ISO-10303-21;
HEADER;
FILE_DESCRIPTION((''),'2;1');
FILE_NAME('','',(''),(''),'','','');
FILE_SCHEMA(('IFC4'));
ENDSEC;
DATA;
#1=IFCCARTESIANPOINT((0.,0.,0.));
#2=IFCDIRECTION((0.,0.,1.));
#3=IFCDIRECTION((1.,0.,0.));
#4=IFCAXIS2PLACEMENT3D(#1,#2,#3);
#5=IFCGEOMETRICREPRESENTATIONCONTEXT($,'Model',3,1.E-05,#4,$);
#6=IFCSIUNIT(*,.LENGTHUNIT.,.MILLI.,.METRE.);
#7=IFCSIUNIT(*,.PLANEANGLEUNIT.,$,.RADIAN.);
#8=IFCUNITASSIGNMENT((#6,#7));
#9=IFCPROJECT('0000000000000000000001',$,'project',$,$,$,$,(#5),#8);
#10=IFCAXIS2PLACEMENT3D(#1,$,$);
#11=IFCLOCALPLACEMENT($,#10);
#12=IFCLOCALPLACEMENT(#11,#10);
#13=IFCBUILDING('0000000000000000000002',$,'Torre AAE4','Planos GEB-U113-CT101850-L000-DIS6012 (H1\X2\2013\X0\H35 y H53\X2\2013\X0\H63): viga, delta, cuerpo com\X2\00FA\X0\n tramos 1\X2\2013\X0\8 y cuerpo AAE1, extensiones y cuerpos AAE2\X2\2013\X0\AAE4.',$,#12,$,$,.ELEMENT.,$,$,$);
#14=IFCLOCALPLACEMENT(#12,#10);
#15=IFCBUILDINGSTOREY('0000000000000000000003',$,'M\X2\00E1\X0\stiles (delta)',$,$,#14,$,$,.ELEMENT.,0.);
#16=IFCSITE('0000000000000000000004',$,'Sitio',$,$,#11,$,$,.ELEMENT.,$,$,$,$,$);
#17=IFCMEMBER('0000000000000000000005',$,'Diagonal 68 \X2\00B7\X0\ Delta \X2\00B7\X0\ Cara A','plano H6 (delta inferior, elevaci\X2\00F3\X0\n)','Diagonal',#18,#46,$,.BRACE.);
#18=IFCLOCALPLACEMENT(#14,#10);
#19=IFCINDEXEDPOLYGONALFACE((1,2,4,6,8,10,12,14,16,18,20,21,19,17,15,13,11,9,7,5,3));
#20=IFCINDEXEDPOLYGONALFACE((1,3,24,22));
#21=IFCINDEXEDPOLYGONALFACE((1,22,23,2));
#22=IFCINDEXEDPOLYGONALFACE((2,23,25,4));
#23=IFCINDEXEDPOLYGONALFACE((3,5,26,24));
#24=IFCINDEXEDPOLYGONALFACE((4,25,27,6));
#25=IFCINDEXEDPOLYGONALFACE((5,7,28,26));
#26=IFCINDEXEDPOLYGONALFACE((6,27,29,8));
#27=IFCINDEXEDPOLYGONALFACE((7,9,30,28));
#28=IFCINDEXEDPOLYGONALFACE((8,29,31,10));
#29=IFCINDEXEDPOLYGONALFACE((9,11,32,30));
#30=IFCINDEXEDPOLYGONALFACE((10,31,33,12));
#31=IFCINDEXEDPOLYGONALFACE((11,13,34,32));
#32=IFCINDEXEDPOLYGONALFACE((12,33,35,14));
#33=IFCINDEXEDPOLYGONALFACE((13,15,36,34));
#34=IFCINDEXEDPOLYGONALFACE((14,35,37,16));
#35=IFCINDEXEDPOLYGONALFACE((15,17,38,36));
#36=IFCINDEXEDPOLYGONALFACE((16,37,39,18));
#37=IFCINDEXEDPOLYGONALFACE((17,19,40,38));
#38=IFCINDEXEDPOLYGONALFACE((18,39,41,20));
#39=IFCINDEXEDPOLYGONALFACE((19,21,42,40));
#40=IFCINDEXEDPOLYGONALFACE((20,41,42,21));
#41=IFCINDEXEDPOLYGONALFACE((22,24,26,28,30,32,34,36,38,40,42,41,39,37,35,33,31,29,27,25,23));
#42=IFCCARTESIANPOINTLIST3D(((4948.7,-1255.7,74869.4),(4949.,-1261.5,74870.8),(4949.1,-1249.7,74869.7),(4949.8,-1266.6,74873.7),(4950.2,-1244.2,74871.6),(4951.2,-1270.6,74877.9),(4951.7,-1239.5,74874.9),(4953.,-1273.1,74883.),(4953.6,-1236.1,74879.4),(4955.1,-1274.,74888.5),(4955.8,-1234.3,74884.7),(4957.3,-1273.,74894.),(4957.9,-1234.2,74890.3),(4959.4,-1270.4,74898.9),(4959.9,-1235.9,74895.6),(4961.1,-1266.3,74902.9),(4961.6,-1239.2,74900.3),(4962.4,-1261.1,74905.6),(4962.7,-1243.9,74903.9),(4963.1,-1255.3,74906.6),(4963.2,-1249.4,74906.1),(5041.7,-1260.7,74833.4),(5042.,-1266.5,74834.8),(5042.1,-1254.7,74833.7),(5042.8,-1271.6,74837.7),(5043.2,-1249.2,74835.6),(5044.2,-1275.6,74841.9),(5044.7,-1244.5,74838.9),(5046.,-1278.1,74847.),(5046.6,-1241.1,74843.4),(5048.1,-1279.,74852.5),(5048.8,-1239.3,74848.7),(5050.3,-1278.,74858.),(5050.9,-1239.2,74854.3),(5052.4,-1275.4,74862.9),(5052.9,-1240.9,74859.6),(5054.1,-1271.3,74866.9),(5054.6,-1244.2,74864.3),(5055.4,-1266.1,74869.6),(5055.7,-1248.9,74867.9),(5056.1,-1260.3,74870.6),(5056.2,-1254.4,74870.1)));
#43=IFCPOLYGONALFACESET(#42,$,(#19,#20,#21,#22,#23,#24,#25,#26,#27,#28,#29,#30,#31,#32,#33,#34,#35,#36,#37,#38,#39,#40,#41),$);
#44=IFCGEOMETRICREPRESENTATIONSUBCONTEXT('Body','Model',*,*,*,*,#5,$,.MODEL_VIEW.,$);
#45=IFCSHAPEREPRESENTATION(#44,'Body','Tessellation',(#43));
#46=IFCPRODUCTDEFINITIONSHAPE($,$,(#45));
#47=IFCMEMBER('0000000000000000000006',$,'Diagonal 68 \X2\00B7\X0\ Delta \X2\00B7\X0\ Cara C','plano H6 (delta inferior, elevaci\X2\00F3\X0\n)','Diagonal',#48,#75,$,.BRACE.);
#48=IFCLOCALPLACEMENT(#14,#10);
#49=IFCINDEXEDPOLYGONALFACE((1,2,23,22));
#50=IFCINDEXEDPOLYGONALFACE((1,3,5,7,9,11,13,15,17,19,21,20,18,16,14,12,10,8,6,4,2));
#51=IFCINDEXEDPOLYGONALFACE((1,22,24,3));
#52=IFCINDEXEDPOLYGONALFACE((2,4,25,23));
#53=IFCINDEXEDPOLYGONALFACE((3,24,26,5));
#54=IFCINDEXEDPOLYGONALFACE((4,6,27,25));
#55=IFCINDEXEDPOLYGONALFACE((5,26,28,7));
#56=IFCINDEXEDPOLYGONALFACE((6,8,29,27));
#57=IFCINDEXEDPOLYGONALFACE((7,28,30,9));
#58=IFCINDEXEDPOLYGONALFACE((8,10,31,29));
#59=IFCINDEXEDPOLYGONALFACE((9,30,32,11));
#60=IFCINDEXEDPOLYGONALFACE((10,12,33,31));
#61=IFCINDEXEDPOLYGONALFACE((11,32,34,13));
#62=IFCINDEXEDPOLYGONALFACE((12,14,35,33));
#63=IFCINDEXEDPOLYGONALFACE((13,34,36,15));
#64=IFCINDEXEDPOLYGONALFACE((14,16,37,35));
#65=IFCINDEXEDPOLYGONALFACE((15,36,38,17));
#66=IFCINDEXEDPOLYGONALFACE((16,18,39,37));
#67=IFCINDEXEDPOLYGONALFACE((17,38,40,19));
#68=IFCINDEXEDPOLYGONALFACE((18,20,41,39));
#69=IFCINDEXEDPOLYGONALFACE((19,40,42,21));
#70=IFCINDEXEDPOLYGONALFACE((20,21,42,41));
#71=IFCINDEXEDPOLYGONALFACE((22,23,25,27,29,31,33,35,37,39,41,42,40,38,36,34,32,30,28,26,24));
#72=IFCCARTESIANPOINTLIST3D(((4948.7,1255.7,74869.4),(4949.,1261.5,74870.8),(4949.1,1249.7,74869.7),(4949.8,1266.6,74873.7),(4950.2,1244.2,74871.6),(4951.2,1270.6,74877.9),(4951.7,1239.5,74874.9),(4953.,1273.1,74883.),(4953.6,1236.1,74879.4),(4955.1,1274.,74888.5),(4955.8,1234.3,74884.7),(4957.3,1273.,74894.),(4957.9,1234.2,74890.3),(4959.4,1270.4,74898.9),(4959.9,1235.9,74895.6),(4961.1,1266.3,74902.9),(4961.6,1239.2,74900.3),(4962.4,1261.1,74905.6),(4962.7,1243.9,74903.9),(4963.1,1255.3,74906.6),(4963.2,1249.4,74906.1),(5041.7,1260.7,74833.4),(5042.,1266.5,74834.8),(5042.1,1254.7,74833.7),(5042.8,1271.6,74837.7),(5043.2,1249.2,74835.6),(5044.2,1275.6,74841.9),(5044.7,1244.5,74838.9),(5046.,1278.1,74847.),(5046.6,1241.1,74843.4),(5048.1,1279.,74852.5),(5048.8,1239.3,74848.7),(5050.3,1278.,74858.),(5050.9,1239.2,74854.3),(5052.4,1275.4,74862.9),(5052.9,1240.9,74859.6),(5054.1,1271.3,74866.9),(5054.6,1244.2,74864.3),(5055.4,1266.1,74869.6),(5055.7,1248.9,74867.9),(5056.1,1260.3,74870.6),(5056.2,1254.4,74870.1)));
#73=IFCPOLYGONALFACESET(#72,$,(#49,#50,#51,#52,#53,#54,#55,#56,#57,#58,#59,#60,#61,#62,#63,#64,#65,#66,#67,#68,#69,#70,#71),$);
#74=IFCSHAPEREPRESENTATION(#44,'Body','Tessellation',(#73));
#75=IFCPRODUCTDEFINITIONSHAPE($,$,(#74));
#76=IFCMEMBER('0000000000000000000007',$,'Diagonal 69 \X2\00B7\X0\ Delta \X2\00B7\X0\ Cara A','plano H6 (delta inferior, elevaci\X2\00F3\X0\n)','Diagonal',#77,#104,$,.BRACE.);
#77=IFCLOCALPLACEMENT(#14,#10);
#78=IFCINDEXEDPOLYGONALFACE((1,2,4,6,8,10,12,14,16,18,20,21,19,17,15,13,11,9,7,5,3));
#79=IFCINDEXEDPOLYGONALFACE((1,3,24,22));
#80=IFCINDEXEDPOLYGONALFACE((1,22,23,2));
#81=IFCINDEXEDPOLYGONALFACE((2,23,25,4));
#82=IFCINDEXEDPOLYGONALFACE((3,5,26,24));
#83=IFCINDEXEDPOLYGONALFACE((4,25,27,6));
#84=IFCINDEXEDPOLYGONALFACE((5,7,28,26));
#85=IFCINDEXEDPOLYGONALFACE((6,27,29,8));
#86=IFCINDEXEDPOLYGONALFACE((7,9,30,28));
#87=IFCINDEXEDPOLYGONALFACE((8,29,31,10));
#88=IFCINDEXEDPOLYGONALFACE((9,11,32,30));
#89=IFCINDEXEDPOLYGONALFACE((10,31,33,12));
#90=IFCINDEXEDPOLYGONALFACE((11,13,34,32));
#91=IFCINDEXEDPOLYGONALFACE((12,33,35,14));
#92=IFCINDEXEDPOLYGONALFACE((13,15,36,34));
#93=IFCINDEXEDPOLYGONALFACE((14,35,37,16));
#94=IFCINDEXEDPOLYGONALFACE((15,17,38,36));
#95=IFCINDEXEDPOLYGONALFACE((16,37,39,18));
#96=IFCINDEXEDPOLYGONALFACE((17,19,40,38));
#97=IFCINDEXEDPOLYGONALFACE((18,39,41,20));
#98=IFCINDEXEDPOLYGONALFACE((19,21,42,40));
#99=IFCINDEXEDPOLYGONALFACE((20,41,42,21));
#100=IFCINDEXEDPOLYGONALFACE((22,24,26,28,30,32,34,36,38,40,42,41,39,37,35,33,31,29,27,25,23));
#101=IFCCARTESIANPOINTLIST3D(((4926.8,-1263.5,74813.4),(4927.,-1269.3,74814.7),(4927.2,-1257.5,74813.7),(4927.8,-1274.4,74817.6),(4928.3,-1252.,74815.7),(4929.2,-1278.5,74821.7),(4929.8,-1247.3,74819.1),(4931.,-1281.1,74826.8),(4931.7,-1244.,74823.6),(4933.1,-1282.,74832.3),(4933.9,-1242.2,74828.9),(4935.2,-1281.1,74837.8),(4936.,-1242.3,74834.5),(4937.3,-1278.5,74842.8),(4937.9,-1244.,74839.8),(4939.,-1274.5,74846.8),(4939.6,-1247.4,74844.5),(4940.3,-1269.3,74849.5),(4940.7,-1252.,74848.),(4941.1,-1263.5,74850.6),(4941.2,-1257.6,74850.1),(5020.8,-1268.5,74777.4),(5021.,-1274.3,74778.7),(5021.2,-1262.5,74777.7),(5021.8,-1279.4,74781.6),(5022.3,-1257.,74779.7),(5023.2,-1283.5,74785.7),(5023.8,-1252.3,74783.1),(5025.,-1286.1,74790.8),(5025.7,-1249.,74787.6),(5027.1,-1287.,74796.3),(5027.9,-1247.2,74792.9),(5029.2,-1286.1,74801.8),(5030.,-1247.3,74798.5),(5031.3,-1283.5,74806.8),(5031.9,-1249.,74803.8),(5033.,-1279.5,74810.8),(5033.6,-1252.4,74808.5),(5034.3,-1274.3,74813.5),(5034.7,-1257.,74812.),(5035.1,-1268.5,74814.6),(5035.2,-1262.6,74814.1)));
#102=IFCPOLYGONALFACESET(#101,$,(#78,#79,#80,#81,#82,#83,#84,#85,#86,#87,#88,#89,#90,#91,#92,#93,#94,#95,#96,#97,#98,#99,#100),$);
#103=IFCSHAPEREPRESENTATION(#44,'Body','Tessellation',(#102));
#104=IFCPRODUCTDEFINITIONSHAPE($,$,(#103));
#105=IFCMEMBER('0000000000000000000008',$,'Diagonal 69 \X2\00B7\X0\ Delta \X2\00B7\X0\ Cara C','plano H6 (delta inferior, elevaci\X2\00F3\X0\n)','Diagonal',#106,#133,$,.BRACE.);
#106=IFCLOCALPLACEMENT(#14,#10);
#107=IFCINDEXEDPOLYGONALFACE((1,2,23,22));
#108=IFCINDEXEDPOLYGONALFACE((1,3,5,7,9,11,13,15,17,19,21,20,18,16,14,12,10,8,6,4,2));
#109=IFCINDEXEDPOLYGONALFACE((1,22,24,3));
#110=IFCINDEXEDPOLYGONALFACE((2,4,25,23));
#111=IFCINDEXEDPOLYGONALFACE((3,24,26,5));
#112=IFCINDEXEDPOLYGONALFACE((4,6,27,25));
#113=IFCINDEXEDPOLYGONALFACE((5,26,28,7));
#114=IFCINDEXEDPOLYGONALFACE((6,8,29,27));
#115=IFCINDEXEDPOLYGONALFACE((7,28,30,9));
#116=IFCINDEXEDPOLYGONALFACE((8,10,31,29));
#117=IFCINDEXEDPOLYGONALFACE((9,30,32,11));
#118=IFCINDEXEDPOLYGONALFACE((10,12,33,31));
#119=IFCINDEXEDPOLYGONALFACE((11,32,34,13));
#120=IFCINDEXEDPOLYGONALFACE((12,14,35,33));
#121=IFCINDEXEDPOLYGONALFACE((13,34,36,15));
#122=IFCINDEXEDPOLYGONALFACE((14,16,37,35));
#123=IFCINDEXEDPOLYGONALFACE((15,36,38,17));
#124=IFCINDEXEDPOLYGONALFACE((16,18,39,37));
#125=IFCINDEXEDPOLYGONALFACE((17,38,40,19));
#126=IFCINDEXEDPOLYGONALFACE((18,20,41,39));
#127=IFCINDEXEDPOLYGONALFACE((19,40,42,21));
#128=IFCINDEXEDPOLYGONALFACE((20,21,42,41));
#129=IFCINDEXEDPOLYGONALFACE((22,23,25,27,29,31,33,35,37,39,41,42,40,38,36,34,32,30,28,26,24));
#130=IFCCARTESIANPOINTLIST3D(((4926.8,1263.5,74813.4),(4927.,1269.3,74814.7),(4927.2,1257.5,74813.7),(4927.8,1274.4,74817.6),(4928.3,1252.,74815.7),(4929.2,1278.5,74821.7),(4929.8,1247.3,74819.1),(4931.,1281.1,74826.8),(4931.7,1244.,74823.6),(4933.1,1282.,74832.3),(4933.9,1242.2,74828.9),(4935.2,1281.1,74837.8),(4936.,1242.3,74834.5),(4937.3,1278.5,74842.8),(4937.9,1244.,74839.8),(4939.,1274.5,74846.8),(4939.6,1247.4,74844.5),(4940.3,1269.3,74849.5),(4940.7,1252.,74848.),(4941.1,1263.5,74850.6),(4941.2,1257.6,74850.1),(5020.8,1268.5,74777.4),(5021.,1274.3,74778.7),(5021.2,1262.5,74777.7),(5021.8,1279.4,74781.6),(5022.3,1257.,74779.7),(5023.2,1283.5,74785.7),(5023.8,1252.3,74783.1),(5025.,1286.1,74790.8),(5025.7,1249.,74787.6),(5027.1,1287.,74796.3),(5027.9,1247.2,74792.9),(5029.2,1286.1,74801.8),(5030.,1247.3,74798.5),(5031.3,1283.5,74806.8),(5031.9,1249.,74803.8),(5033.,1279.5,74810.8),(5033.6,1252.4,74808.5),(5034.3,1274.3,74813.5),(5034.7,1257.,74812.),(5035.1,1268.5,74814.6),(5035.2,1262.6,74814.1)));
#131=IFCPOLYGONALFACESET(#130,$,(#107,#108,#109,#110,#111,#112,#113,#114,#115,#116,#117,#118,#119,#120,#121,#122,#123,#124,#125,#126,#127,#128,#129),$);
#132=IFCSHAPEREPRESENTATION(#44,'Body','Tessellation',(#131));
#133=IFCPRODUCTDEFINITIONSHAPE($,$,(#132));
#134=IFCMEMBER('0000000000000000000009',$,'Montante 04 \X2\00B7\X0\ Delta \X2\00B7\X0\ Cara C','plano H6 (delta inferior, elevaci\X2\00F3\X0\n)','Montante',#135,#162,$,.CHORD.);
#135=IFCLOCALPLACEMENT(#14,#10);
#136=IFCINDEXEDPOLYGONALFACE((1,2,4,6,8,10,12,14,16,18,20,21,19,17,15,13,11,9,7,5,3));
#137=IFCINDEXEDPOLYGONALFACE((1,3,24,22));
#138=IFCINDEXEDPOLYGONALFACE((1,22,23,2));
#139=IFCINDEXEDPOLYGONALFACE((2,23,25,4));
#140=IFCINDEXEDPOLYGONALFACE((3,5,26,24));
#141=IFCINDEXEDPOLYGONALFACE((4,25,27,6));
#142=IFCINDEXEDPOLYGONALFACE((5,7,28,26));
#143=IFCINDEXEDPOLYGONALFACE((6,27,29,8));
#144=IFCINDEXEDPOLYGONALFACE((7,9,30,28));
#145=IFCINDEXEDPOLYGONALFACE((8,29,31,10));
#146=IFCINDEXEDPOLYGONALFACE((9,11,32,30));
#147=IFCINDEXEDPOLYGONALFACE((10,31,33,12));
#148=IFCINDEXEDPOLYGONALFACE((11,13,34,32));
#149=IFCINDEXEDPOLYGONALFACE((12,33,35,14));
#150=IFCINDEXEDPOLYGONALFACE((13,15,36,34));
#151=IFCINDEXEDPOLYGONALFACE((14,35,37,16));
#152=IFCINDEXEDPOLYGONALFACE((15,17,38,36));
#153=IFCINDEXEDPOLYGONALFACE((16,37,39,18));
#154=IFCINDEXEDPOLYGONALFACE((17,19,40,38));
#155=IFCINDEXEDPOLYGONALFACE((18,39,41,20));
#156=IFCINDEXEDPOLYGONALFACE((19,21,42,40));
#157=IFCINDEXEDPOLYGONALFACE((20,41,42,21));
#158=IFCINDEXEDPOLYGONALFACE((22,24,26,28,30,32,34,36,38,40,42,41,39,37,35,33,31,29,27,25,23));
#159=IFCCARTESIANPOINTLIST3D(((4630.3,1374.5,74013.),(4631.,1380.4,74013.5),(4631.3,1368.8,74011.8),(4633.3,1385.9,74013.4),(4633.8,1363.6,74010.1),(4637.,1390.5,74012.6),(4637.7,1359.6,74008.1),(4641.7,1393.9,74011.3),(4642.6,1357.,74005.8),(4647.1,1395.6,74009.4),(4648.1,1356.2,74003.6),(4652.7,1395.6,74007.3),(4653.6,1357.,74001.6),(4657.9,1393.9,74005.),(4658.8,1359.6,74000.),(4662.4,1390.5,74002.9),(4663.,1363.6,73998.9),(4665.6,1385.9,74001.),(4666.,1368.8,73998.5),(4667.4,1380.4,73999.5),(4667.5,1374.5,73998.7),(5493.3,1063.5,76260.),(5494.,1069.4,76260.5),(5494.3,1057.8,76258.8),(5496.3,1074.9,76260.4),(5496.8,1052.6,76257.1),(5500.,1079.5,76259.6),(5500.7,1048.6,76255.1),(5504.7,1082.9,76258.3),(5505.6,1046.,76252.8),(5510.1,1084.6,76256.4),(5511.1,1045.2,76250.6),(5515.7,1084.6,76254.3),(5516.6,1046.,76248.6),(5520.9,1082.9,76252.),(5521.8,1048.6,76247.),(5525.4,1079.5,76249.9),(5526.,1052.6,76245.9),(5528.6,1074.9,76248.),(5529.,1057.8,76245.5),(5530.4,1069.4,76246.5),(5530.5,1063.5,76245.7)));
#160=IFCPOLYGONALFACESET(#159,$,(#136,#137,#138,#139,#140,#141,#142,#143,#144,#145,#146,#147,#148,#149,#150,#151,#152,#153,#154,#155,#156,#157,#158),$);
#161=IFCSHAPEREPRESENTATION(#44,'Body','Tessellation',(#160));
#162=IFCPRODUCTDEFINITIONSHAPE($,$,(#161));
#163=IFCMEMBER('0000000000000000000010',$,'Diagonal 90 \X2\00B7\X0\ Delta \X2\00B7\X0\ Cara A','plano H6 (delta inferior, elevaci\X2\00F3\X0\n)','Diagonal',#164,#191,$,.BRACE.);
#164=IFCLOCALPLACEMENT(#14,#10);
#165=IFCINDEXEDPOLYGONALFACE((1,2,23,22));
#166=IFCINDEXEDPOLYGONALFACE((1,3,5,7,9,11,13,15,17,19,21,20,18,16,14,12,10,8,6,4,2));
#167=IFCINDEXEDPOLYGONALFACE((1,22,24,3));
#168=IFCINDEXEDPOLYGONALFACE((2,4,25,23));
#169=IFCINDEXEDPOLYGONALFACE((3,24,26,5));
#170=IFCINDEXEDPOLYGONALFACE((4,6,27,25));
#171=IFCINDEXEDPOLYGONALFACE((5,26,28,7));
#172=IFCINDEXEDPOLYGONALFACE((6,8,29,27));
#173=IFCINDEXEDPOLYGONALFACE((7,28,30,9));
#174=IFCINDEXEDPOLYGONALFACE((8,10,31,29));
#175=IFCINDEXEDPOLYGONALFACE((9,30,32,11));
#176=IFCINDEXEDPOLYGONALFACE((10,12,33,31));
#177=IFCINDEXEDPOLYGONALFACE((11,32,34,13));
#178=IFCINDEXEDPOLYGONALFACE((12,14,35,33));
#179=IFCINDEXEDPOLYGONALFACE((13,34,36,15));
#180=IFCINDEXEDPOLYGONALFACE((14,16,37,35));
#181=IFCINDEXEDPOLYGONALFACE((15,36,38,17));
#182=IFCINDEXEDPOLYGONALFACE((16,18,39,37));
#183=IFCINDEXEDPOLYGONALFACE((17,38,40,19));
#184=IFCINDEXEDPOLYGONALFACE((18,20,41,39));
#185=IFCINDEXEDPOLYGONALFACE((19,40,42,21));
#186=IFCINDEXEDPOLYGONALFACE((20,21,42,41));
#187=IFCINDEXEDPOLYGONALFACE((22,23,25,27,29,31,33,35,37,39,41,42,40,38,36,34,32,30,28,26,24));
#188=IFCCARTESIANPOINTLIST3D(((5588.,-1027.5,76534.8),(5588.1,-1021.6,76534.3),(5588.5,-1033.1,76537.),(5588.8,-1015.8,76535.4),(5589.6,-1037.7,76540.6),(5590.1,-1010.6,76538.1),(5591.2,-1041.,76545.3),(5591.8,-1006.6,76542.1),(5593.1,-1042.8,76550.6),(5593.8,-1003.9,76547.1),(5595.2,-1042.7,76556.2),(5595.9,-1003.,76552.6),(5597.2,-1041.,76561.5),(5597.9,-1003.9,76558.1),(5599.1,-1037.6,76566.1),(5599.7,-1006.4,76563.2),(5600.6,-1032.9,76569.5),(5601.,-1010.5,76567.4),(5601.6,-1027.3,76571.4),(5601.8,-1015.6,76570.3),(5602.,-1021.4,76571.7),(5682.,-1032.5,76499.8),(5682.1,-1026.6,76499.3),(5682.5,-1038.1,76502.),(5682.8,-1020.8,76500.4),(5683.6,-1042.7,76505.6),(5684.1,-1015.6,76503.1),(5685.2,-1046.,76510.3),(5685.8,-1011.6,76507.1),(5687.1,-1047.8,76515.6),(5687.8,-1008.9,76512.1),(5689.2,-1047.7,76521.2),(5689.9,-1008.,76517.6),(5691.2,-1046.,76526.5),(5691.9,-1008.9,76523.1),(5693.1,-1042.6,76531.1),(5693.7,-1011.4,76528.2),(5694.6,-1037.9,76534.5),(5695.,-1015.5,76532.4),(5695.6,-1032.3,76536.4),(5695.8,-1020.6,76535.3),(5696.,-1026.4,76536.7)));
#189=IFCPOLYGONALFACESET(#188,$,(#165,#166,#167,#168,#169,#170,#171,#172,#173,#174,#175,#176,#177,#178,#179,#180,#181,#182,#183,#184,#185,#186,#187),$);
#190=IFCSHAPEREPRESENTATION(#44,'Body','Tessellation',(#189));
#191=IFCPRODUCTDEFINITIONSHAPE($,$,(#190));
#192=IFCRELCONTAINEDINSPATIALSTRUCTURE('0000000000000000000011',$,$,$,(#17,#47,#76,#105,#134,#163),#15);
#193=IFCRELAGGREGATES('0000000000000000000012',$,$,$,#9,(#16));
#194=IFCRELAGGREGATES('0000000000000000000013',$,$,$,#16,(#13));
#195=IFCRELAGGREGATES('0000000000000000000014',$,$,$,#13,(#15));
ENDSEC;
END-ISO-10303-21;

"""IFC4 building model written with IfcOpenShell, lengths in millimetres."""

from ifc_helpers import new_model, si_unit, frame, origin, origin_with_axes, place, context, subcontext, project, spatial, circle, extrude, element, save


model = new_model("IFC4")

# Units and contexts
model_context = context("Model", 3, precision=1e-05, world=origin_with_axes())
body_context = subcontext(model_context, "Body", "Model", "MODEL_VIEW")
ifc_project = project(units=[si_unit("LENGTHUNIT", "METRE", prefix="MILLI"), si_unit("PLANEANGLEUNIT", "RADIAN")], contexts=[model_context])

# Site, building, storey
site_placement = place(None, origin())
site = spatial("IfcSite", under=ifc_project, at=site_placement, Name="Sitio", CompositionType="ELEMENT")
building_placement = place(site_placement, origin())
building = spatial("IfcBuilding", under=site, at=building_placement, Name="Torre AAE4", Description="Planos GEB-U113-CT101850-L000-DIS6012 (H1–H35 y H53–H63): viga, delta, cuerpo común tramos 1–8 y cuerpo AAE1, extensiones y cuerpos AAE2–AAE4.", CompositionType="ELEMENT")
storey_placement = place(building_placement, origin())
storey = spatial("IfcBuildingStorey", under=building, at=storey_placement, Name="Mástiles (delta)", CompositionType="ELEMENT", Elevation=0.0)

# Members
for number, where, z_axis, x_axis, name in (
    (1, (4956.0, -1254.0, 74888.0), (0.931398, -0.050075, -0.360541), (-0.291234, 0.49166, -0.820642), "Diagonal 68 · Delta · Cara A"),
    (2, (4956.0, 1254.0, 74888.0), (0.931398, 0.050075, -0.360541), (-0.291234, -0.49166, -0.820642), "Diagonal 68 · Delta · Cara C"),
):
    element("IfcMember", number, at=place(storey_placement, frame(where, z_axis=z_axis, x_axis=x_axis)), inside=storey, Name=name, Description="plano H6 (delta inferior, elevación)", ObjectType="Diagonal", PredefinedType="BRACE", context=body_context, shape_type="SweptSolid", body=[
        extrude(circle(Radius=20.0), None, (0.0, 0.0, 1.0), 99.8),
    ])
for number, where, z_axis, x_axis, name in (
    (3, (4934.0, -1262.0, 74832.0), (0.932707, -0.049612, -0.357207), (-0.286229, 0.500713, -0.81692), "Diagonal 69 · Delta · Cara A"),
    (4, (4934.0, 1262.0, 74832.0), (0.932707, 0.049612, -0.357207), (-0.286229, -0.500713, -0.81692), "Diagonal 69 · Delta · Cara C"),
):
    element("IfcMember", number, at=place(storey_placement, frame(where, z_axis=z_axis, x_axis=x_axis)), inside=storey, Name=name, Description="plano H6 (delta inferior, elevación)", ObjectType="Diagonal", PredefinedType="BRACE", context=body_context, shape_type="SweptSolid", body=[
        extrude(circle(Radius=20.0), None, (0.0, 0.0, 1.0), 100.8),
    ])
for number, where, z_axis, x_axis, name in (
    (5, (5512.0, 1065.0, 76253.0), (-0.355578, 0.12814, -0.925821), (-0.045942, -0.991756, -0.119621), "Montante 04 · Delta · Cara C"),
):
    element("IfcMember", number, at=place(storey_placement, frame(where, z_axis=z_axis, x_axis=x_axis)), inside=storey, Name=name, Description="plano H6 (delta inferior, elevación)", ObjectType="Montante", PredefinedType="CHORD", context=body_context, shape_type="SweptSolid", body=[
        extrude(circle(Radius=20.0), None, (0.0, 0.0, 1.0), 2427.0),
    ])
for number, where, z_axis, x_axis, name in (
    (6, (5595.0, -1023.0, 76553.0), (0.935984, -0.049786, -0.348505), (-0.308647, 0.360098, -0.880379), "Diagonal 90 · Delta · Cara A"),
):
    element("IfcMember", number, at=place(storey_placement, frame(where, z_axis=z_axis, x_axis=x_axis)), inside=storey, Name=name, Description="plano H6 (delta inferior, elevación)", ObjectType="Diagonal", PredefinedType="BRACE", context=body_context, shape_type="SweptSolid", body=[
        extrude(circle(Radius=20.0), None, (0.0, 0.0, 1.0), 100.4),
    ])

save(model, "model.ifc")
